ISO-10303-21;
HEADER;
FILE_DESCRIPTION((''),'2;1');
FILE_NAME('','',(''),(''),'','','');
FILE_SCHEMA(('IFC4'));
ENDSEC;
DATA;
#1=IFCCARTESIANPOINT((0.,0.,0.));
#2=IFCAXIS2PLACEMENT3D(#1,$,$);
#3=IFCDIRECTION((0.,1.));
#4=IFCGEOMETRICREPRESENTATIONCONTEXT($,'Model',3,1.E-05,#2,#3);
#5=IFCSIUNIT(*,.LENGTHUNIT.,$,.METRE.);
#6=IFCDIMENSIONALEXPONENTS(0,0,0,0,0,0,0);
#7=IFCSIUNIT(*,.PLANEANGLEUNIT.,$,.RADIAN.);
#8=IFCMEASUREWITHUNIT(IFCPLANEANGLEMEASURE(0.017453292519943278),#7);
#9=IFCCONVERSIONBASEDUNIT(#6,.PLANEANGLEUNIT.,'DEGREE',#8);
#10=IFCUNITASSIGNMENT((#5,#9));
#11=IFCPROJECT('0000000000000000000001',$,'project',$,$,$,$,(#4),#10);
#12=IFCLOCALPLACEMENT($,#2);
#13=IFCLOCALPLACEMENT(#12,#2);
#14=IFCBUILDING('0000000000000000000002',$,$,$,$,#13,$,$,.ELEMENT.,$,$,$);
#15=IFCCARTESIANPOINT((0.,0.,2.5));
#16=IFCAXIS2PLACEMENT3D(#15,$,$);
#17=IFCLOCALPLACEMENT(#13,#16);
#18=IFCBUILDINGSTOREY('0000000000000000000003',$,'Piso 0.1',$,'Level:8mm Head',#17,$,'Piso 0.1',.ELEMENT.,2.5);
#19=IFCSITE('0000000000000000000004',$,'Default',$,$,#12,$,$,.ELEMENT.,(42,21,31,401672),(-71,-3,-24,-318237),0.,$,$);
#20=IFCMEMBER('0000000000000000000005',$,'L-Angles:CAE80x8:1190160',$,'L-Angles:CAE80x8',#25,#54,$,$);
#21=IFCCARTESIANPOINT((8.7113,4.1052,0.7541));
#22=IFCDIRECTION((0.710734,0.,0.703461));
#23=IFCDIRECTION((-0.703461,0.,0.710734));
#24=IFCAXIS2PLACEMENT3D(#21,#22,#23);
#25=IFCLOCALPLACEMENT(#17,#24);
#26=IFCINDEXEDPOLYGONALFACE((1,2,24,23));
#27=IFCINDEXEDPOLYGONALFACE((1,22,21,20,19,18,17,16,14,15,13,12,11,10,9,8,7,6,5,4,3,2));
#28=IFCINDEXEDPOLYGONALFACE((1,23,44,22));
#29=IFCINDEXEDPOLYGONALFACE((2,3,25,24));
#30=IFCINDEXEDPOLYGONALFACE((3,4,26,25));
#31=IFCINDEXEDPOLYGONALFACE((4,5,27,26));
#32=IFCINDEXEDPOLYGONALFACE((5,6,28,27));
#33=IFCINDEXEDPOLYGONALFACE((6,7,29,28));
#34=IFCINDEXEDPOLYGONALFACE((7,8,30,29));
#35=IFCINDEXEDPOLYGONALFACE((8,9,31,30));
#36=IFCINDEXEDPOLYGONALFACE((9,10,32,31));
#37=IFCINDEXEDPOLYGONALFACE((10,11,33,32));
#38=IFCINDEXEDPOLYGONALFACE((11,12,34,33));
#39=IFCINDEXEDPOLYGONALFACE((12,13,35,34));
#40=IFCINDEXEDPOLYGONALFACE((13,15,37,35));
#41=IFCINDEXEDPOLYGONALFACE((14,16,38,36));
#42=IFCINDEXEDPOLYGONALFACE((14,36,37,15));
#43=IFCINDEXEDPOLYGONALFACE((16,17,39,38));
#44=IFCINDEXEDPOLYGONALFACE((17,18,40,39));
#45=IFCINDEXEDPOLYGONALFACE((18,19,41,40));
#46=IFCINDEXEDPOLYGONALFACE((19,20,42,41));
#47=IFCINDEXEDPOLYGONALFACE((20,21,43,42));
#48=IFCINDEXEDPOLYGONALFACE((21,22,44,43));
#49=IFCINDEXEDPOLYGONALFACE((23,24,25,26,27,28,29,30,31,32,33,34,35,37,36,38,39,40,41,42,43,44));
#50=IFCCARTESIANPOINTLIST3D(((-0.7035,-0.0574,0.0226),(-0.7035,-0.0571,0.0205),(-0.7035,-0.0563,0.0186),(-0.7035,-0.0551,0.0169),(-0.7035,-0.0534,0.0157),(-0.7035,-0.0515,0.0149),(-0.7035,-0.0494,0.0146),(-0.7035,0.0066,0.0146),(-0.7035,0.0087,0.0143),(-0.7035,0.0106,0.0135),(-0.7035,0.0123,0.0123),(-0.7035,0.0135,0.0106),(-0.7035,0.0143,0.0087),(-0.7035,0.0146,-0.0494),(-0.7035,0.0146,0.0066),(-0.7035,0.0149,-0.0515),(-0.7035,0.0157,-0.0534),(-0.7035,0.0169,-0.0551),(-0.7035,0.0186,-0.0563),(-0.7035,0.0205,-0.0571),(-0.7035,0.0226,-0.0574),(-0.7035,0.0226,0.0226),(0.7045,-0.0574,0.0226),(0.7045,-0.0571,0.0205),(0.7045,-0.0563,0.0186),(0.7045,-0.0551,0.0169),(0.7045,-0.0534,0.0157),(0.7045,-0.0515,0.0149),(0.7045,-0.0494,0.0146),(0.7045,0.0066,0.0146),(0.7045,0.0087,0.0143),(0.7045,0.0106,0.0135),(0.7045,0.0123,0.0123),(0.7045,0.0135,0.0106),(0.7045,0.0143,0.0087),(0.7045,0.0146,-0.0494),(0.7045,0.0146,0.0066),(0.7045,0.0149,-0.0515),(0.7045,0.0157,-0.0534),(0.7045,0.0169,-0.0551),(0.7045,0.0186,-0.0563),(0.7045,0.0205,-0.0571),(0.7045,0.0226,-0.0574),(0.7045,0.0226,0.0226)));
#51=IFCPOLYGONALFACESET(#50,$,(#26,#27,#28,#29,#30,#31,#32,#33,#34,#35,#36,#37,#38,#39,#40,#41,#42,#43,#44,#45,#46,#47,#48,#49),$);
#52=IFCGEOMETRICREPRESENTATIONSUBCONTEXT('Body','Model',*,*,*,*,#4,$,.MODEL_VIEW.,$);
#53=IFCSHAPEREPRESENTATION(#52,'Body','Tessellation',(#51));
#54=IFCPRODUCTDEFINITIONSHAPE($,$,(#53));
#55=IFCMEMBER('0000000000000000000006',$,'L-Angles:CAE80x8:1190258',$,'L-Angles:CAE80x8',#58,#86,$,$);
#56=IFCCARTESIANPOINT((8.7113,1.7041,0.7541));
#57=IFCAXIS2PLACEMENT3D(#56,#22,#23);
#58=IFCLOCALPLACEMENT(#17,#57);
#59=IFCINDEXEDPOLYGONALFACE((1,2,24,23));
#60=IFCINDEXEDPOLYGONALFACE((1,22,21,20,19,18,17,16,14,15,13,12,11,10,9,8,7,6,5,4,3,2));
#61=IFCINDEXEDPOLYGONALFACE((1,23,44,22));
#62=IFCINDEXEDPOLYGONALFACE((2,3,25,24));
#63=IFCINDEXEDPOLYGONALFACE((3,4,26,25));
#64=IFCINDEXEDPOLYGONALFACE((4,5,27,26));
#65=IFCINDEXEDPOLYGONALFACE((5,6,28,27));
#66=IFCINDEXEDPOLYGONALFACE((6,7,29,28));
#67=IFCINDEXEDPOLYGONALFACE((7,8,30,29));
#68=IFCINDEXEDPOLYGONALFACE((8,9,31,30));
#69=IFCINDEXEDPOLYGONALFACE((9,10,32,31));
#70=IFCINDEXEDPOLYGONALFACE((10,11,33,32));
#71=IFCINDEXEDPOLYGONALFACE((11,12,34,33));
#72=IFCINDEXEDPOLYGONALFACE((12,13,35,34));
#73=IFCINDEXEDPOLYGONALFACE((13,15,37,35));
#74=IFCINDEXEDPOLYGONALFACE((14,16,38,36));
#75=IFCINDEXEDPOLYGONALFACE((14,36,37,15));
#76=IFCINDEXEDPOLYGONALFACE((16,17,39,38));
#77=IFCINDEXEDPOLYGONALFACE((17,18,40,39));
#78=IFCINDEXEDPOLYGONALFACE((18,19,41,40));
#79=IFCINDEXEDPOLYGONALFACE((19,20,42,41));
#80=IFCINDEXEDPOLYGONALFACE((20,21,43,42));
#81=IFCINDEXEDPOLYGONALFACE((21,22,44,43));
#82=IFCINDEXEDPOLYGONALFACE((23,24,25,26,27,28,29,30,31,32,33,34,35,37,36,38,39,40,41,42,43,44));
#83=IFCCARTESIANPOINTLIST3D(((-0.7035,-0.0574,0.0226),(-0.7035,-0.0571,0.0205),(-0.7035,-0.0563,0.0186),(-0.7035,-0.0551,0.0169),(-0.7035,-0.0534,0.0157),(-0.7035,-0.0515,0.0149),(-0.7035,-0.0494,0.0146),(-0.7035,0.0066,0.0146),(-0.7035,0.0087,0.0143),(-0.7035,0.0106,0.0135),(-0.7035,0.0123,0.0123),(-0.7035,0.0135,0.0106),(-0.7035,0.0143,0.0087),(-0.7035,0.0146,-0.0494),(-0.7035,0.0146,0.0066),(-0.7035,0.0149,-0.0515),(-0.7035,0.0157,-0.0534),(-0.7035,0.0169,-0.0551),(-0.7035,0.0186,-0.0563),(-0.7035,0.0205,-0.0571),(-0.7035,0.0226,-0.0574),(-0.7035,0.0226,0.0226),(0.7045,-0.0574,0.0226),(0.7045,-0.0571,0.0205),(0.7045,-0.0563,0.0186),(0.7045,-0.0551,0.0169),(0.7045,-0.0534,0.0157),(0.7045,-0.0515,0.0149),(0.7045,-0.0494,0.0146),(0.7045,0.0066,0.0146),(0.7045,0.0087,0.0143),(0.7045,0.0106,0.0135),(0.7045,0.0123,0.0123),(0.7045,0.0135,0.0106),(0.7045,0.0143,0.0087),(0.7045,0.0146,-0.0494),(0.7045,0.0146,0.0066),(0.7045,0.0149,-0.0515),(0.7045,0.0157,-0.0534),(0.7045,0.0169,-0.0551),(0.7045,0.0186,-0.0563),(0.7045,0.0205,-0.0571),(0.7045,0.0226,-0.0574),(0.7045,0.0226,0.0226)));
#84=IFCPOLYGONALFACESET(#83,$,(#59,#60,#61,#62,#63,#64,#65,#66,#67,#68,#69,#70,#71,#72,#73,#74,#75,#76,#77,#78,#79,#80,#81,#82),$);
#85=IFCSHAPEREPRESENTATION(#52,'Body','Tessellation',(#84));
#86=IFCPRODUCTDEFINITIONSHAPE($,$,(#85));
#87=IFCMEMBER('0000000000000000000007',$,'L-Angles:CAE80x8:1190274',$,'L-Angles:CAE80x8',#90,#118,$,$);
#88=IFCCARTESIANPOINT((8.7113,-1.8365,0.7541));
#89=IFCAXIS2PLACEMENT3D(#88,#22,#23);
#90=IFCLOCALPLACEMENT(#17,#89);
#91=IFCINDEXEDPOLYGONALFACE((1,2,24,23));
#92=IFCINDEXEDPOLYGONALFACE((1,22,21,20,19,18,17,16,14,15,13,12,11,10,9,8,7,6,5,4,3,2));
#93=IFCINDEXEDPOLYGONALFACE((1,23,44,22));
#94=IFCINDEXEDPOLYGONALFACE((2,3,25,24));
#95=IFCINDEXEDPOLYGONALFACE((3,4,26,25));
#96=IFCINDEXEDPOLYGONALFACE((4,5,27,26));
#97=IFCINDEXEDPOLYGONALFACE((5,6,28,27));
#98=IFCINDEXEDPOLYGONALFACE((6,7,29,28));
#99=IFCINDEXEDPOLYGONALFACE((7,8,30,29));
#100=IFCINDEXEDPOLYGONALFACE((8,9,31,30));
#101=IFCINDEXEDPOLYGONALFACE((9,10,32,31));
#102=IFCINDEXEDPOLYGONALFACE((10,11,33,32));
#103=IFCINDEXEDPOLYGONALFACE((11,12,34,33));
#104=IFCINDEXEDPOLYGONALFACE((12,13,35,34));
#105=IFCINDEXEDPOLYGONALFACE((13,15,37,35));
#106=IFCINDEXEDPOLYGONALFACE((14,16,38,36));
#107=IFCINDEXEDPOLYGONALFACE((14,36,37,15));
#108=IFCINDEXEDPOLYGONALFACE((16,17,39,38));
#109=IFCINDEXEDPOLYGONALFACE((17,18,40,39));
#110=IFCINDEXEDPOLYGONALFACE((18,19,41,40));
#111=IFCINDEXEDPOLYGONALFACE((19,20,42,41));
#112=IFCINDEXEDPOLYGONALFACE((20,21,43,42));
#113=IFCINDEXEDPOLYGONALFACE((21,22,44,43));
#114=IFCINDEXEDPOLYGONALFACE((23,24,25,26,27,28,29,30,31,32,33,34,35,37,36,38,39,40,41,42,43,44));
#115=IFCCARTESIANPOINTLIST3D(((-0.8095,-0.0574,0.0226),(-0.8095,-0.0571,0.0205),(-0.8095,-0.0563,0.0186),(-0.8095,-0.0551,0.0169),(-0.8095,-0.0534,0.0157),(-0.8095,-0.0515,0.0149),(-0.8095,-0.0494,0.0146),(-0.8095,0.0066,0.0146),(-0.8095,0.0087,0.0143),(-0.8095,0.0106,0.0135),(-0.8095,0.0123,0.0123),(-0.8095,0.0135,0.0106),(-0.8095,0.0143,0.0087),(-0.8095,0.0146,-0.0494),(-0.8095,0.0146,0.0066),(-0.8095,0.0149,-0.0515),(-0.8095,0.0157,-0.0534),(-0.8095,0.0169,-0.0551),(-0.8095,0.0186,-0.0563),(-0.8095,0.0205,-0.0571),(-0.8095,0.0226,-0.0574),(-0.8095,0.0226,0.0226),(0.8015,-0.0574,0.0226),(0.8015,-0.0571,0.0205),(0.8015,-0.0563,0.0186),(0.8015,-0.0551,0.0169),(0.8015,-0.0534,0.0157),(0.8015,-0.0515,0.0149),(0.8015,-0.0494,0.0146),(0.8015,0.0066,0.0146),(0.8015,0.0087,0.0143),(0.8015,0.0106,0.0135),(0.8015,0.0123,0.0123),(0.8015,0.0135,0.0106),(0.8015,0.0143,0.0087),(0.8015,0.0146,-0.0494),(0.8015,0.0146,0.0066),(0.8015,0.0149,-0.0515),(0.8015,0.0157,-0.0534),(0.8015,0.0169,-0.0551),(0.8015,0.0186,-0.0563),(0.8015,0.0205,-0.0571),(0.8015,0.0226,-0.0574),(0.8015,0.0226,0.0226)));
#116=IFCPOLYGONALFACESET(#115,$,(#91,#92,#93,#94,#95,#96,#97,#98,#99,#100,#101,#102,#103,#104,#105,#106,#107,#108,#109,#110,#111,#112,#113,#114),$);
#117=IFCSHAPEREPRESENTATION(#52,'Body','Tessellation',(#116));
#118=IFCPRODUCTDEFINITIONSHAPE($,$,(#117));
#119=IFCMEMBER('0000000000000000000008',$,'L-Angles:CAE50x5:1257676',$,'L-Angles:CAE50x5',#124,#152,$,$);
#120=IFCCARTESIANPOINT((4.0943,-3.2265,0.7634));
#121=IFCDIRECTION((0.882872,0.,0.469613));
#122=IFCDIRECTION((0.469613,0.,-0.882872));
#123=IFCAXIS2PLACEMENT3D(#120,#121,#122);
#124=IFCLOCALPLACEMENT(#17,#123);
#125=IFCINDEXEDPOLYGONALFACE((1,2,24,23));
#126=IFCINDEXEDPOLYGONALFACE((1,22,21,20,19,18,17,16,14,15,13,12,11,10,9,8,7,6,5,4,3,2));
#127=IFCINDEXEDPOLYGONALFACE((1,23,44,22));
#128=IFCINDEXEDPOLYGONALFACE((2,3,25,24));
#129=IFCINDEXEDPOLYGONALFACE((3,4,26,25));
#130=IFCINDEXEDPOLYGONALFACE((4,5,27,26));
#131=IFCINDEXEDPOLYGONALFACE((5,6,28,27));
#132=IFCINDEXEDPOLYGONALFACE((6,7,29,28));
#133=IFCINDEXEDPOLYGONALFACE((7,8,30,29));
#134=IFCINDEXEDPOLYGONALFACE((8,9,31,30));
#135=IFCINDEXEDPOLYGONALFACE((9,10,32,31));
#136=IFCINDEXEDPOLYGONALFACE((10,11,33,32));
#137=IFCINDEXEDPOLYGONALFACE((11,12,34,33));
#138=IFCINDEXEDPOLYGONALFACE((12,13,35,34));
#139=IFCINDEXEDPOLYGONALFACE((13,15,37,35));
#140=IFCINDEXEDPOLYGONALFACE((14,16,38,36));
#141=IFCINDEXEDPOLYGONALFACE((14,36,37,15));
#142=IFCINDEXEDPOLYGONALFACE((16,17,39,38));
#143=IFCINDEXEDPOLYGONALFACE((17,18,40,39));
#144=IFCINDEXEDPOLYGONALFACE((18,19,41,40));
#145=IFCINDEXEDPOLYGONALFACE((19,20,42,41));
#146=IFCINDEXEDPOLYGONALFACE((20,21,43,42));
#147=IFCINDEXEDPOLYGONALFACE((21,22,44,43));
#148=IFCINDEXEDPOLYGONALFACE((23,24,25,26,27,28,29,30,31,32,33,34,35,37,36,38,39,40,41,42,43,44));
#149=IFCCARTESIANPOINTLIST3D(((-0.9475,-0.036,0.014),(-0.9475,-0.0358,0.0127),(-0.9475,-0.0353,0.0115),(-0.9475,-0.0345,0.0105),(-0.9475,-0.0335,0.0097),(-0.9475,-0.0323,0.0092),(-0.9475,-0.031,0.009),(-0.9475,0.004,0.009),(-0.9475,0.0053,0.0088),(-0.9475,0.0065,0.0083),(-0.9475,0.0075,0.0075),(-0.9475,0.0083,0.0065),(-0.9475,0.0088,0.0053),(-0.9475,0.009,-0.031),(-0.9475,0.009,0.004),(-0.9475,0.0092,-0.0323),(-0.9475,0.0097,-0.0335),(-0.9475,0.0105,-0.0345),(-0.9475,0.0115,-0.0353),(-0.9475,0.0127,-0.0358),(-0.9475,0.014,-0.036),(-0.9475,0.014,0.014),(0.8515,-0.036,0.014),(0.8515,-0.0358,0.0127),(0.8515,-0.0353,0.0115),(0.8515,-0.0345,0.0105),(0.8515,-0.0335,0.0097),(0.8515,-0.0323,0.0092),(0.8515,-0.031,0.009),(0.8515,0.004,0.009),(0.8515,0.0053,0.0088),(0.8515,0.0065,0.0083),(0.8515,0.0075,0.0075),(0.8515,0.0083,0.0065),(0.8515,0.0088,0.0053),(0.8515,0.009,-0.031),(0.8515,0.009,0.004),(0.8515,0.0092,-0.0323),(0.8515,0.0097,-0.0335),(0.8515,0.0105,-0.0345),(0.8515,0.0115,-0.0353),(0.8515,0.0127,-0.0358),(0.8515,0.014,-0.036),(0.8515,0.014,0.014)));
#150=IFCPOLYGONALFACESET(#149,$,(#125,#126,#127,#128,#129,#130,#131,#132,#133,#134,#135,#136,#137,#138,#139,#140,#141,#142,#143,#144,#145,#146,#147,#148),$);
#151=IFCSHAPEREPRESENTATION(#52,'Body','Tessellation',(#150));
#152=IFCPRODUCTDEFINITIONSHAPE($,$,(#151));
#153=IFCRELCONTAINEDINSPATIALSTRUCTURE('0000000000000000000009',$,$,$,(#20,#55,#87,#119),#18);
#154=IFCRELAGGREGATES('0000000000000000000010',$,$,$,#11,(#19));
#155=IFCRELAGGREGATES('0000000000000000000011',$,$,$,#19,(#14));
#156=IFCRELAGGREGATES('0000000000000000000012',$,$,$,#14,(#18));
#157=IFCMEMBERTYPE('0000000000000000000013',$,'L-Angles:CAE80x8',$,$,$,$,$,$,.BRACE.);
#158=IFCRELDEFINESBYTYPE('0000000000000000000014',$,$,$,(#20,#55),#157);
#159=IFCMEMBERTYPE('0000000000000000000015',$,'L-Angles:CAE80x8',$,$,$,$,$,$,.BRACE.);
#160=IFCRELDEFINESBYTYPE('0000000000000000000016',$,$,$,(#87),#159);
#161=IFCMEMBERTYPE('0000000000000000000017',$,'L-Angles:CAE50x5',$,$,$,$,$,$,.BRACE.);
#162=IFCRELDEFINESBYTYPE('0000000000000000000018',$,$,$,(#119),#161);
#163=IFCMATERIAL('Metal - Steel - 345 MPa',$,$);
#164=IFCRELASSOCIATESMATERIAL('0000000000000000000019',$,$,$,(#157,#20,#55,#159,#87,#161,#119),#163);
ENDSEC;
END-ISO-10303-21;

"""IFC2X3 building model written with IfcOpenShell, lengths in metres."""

from ifc_helpers import new_model, entity, si_unit, converted_unit, direction, frame, frame_2d, origin, place, context, subcontext, project, spatial, polyline, circle_curve, parameter, trimmed, segment, composite_curve, outline, extrude, source, transform, mapped, material, type_object, type_shapes, element, save


model = new_model("IFC2X3")

# Units and contexts
model_context = context("Model", 3, precision=1e-05, world=origin(), true_north=direction((0.0, 1.0)))
body_context = subcontext(model_context, "Body", "Model", "MODEL_VIEW")
ifc_project = project(units=[si_unit("LENGTHUNIT", "METRE"), converted_unit("PLANEANGLEUNIT", "DEGREE", entity("IfcPlaneAngleMeasure", 0.017453292519943278), si_unit("PLANEANGLEUNIT", "RADIAN"), dimensions=[0, 0, 0, 0, 0, 0, 0])], contexts=[model_context])

# Site, building, storey
site_placement = place(None, origin())
site = spatial("IfcSite", under=ifc_project, at=site_placement, Name="Default", CompositionType="ELEMENT", RefLatitude=(42, 21, 31, 401672), RefLongitude=(-71, -3, -24, -318237), RefElevation=0.0)
building_placement = place(site_placement, origin())
building = spatial("IfcBuilding", under=site, at=building_placement, CompositionType="ELEMENT")
storey_placement = place(building_placement, frame((0.0, 0.0, 2.5)))
storey = spatial("IfcBuildingStorey", under=building, at=storey_placement, Name="Piso 0.1", ObjectType="Level:8mm Head", LongName="Piso 0.1", CompositionType="ELEMENT", Elevation=2.5)

# Members
ifc_material = material(Name="Metal - Steel - 345 MPa")
member_type_1 = type_object("IfcMemberType", Name="L-Angles:CAE80x8", PredefinedType="BRACE", material=ifc_material)
shared_shape_1 = source(origin(), body_context, "Body", "SweptSolid", [
    extrude(outline(composite_curve([segment(polyline([(-0.0263, -0.0263), (0.0537, -0.0263)]), True, "CONTINUOUS"), segment(trimmed(circle_curve(frame_2d((0.0457, -0.0263), x_axis=(1.0, 0.0)), 0.008), [parameter(0.0)], [parameter(90.0)], True, "PARAMETER"), True, "CONTINUOUS"), segment(polyline([(0.0457, -0.0183), (-0.0103, -0.0183)]), True, "CONTINUOUS"), segment(trimmed(circle_curve(frame_2d((-0.0103, -0.0103), x_axis=(1.0, 0.0)), 0.008), [parameter(180.0)], [parameter(270.0)], True, "PARAMETER"), False, "CONTINUOUS"), segment(polyline([(-0.0183, -0.0103), (-0.0183, 0.0457)]), True, "CONTINUOUS"), segment(trimmed(circle_curve(frame_2d((-0.0263, 0.0457), x_axis=(1.0, 0.0)), 0.008), [parameter(0.0)], [parameter(90.0)], True, "PARAMETER"), True, "CONTINUOUS"), segment(polyline([(-0.0263, 0.0537), (-0.0263, -0.0263)]), True, "CONTINUOUS")], self_intersect=False)), frame((-0.7035, -0.0037, -0.0037), z_axis=(1.0, 0.0, 0.0), x_axis=(0.0, -1.0, 0.0)), (0.0, 0.0, 1.0), 1.408),
])
type_shapes(member_type_1, [shared_shape_1])
for number, where, z_axis, x_axis, name in (
    (1, (8.7113, 4.1052, 0.7541), (0.710734, 0.0, 0.703461), (-0.703461, 0.0, 0.710734), "L-Angles:CAE80x8:1190160"),
    (2, (8.7113, 1.7041, 0.7541), (0.710734, 0.0, 0.703461), (-0.703461, 0.0, 0.710734), "L-Angles:CAE80x8:1190258"),
):
    element("IfcMember", number, at=place(storey_placement, frame(where, z_axis=z_axis, x_axis=x_axis)), inside=storey, type_object=member_type_1, material=ifc_material, Name=name, ObjectType="L-Angles:CAE80x8", context=body_context, shape_type="MappedRepresentation", body=[
        mapped(shared_shape_1, transform((0.0, 0.0, 0.0), scale=1.0)),
    ])
member_type_2 = type_object("IfcMemberType", Name="L-Angles:CAE80x8", PredefinedType="BRACE", material=ifc_material)
shared_shape_2 = source(origin(), body_context, "Body", "SweptSolid", [
    extrude(outline(composite_curve([segment(polyline([(-0.0263, -0.0263), (0.0537, -0.0263)]), True, "CONTINUOUS"), segment(trimmed(circle_curve(frame_2d((0.0457, -0.0263), x_axis=(1.0, 0.0)), 0.008), [parameter(0.0)], [parameter(90.0)], True, "PARAMETER"), True, "CONTINUOUS"), segment(polyline([(0.0457, -0.0183), (-0.0103, -0.0183)]), True, "CONTINUOUS"), segment(trimmed(circle_curve(frame_2d((-0.0103, -0.0103), x_axis=(1.0, 0.0)), 0.008), [parameter(180.0)], [parameter(270.0)], True, "PARAMETER"), False, "CONTINUOUS"), segment(polyline([(-0.0183, -0.0103), (-0.0183, 0.0457)]), True, "CONTINUOUS"), segment(trimmed(circle_curve(frame_2d((-0.0263, 0.0457), x_axis=(1.0, 0.0)), 0.008), [parameter(0.0)], [parameter(90.0)], True, "PARAMETER"), True, "CONTINUOUS"), segment(polyline([(-0.0263, 0.0537), (-0.0263, -0.0263)]), True, "CONTINUOUS")], self_intersect=False)), frame((-0.8095, -0.0037, -0.0037), z_axis=(1.0, 0.0, 0.0), x_axis=(0.0, -1.0, 0.0)), (0.0, 0.0, 1.0), 1.611),
])
type_shapes(member_type_2, [shared_shape_2])
member_1_placement = place(storey_placement, frame((8.7113, -1.8365, 0.7541), z_axis=(0.710734, 0.0, 0.703461), x_axis=(-0.703461, 0.0, 0.710734)))
element("IfcMember", 3, at=member_1_placement, inside=storey, type_object=member_type_2, material=ifc_material, Name="L-Angles:CAE80x8:1190274", ObjectType="L-Angles:CAE80x8", context=body_context, shape_type="MappedRepresentation", body=[
    mapped(shared_shape_2, transform((0.0, 0.0, 0.0), scale=1.0)),
])
member_type_3 = type_object("IfcMemberType", Name="L-Angles:CAE50x5", PredefinedType="BRACE", material=ifc_material)
shared_shape_3 = source(origin(), body_context, "Body", "SweptSolid", [
    extrude(outline(composite_curve([segment(polyline([(-0.0164, -0.0164), (0.0336, -0.0164)]), True, "CONTINUOUS"), segment(trimmed(circle_curve(frame_2d((0.0286, -0.0164), x_axis=(1.0, 0.0)), 0.005), [parameter(0.0)], [parameter(90.0)], True, "PARAMETER"), True, "CONTINUOUS"), segment(polyline([(0.0286, -0.0114), (-0.0064, -0.0114)]), True, "CONTINUOUS"), segment(trimmed(circle_curve(frame_2d((-0.0064, -0.0064), x_axis=(1.0, 0.0)), 0.005), [parameter(180.0)], [parameter(270.0)], True, "PARAMETER"), False, "CONTINUOUS"), segment(polyline([(-0.0114, -0.0064), (-0.0114, 0.0286)]), True, "CONTINUOUS"), segment(trimmed(circle_curve(frame_2d((-0.0164, 0.0286), x_axis=(1.0, 0.0)), 0.005), [parameter(0.0)], [parameter(90.0)], True, "PARAMETER"), True, "CONTINUOUS"), segment(polyline([(-0.0164, 0.0336), (-0.0164, -0.0164)]), True, "CONTINUOUS")], self_intersect=False)), frame((-0.9475, -0.0024, -0.0024), z_axis=(1.0, 0.0, 0.0), x_axis=(0.0, -1.0, 0.0)), (0.0, 0.0, 1.0), 1.799),
])
type_shapes(member_type_3, [shared_shape_3])
member_2_placement = place(storey_placement, frame((4.0943, -3.2265, 0.7634), z_axis=(0.882872, 0.0, 0.469613), x_axis=(0.469613, 0.0, -0.882872)))
element("IfcMember", 4, at=member_2_placement, inside=storey, type_object=member_type_3, material=ifc_material, Name="L-Angles:CAE50x5:1257676", ObjectType="L-Angles:CAE50x5", context=body_context, shape_type="MappedRepresentation", body=[
    mapped(shared_shape_3, transform((0.0, 0.0, 0.0), scale=1.0)),
])

save(model, "model.ifc")
